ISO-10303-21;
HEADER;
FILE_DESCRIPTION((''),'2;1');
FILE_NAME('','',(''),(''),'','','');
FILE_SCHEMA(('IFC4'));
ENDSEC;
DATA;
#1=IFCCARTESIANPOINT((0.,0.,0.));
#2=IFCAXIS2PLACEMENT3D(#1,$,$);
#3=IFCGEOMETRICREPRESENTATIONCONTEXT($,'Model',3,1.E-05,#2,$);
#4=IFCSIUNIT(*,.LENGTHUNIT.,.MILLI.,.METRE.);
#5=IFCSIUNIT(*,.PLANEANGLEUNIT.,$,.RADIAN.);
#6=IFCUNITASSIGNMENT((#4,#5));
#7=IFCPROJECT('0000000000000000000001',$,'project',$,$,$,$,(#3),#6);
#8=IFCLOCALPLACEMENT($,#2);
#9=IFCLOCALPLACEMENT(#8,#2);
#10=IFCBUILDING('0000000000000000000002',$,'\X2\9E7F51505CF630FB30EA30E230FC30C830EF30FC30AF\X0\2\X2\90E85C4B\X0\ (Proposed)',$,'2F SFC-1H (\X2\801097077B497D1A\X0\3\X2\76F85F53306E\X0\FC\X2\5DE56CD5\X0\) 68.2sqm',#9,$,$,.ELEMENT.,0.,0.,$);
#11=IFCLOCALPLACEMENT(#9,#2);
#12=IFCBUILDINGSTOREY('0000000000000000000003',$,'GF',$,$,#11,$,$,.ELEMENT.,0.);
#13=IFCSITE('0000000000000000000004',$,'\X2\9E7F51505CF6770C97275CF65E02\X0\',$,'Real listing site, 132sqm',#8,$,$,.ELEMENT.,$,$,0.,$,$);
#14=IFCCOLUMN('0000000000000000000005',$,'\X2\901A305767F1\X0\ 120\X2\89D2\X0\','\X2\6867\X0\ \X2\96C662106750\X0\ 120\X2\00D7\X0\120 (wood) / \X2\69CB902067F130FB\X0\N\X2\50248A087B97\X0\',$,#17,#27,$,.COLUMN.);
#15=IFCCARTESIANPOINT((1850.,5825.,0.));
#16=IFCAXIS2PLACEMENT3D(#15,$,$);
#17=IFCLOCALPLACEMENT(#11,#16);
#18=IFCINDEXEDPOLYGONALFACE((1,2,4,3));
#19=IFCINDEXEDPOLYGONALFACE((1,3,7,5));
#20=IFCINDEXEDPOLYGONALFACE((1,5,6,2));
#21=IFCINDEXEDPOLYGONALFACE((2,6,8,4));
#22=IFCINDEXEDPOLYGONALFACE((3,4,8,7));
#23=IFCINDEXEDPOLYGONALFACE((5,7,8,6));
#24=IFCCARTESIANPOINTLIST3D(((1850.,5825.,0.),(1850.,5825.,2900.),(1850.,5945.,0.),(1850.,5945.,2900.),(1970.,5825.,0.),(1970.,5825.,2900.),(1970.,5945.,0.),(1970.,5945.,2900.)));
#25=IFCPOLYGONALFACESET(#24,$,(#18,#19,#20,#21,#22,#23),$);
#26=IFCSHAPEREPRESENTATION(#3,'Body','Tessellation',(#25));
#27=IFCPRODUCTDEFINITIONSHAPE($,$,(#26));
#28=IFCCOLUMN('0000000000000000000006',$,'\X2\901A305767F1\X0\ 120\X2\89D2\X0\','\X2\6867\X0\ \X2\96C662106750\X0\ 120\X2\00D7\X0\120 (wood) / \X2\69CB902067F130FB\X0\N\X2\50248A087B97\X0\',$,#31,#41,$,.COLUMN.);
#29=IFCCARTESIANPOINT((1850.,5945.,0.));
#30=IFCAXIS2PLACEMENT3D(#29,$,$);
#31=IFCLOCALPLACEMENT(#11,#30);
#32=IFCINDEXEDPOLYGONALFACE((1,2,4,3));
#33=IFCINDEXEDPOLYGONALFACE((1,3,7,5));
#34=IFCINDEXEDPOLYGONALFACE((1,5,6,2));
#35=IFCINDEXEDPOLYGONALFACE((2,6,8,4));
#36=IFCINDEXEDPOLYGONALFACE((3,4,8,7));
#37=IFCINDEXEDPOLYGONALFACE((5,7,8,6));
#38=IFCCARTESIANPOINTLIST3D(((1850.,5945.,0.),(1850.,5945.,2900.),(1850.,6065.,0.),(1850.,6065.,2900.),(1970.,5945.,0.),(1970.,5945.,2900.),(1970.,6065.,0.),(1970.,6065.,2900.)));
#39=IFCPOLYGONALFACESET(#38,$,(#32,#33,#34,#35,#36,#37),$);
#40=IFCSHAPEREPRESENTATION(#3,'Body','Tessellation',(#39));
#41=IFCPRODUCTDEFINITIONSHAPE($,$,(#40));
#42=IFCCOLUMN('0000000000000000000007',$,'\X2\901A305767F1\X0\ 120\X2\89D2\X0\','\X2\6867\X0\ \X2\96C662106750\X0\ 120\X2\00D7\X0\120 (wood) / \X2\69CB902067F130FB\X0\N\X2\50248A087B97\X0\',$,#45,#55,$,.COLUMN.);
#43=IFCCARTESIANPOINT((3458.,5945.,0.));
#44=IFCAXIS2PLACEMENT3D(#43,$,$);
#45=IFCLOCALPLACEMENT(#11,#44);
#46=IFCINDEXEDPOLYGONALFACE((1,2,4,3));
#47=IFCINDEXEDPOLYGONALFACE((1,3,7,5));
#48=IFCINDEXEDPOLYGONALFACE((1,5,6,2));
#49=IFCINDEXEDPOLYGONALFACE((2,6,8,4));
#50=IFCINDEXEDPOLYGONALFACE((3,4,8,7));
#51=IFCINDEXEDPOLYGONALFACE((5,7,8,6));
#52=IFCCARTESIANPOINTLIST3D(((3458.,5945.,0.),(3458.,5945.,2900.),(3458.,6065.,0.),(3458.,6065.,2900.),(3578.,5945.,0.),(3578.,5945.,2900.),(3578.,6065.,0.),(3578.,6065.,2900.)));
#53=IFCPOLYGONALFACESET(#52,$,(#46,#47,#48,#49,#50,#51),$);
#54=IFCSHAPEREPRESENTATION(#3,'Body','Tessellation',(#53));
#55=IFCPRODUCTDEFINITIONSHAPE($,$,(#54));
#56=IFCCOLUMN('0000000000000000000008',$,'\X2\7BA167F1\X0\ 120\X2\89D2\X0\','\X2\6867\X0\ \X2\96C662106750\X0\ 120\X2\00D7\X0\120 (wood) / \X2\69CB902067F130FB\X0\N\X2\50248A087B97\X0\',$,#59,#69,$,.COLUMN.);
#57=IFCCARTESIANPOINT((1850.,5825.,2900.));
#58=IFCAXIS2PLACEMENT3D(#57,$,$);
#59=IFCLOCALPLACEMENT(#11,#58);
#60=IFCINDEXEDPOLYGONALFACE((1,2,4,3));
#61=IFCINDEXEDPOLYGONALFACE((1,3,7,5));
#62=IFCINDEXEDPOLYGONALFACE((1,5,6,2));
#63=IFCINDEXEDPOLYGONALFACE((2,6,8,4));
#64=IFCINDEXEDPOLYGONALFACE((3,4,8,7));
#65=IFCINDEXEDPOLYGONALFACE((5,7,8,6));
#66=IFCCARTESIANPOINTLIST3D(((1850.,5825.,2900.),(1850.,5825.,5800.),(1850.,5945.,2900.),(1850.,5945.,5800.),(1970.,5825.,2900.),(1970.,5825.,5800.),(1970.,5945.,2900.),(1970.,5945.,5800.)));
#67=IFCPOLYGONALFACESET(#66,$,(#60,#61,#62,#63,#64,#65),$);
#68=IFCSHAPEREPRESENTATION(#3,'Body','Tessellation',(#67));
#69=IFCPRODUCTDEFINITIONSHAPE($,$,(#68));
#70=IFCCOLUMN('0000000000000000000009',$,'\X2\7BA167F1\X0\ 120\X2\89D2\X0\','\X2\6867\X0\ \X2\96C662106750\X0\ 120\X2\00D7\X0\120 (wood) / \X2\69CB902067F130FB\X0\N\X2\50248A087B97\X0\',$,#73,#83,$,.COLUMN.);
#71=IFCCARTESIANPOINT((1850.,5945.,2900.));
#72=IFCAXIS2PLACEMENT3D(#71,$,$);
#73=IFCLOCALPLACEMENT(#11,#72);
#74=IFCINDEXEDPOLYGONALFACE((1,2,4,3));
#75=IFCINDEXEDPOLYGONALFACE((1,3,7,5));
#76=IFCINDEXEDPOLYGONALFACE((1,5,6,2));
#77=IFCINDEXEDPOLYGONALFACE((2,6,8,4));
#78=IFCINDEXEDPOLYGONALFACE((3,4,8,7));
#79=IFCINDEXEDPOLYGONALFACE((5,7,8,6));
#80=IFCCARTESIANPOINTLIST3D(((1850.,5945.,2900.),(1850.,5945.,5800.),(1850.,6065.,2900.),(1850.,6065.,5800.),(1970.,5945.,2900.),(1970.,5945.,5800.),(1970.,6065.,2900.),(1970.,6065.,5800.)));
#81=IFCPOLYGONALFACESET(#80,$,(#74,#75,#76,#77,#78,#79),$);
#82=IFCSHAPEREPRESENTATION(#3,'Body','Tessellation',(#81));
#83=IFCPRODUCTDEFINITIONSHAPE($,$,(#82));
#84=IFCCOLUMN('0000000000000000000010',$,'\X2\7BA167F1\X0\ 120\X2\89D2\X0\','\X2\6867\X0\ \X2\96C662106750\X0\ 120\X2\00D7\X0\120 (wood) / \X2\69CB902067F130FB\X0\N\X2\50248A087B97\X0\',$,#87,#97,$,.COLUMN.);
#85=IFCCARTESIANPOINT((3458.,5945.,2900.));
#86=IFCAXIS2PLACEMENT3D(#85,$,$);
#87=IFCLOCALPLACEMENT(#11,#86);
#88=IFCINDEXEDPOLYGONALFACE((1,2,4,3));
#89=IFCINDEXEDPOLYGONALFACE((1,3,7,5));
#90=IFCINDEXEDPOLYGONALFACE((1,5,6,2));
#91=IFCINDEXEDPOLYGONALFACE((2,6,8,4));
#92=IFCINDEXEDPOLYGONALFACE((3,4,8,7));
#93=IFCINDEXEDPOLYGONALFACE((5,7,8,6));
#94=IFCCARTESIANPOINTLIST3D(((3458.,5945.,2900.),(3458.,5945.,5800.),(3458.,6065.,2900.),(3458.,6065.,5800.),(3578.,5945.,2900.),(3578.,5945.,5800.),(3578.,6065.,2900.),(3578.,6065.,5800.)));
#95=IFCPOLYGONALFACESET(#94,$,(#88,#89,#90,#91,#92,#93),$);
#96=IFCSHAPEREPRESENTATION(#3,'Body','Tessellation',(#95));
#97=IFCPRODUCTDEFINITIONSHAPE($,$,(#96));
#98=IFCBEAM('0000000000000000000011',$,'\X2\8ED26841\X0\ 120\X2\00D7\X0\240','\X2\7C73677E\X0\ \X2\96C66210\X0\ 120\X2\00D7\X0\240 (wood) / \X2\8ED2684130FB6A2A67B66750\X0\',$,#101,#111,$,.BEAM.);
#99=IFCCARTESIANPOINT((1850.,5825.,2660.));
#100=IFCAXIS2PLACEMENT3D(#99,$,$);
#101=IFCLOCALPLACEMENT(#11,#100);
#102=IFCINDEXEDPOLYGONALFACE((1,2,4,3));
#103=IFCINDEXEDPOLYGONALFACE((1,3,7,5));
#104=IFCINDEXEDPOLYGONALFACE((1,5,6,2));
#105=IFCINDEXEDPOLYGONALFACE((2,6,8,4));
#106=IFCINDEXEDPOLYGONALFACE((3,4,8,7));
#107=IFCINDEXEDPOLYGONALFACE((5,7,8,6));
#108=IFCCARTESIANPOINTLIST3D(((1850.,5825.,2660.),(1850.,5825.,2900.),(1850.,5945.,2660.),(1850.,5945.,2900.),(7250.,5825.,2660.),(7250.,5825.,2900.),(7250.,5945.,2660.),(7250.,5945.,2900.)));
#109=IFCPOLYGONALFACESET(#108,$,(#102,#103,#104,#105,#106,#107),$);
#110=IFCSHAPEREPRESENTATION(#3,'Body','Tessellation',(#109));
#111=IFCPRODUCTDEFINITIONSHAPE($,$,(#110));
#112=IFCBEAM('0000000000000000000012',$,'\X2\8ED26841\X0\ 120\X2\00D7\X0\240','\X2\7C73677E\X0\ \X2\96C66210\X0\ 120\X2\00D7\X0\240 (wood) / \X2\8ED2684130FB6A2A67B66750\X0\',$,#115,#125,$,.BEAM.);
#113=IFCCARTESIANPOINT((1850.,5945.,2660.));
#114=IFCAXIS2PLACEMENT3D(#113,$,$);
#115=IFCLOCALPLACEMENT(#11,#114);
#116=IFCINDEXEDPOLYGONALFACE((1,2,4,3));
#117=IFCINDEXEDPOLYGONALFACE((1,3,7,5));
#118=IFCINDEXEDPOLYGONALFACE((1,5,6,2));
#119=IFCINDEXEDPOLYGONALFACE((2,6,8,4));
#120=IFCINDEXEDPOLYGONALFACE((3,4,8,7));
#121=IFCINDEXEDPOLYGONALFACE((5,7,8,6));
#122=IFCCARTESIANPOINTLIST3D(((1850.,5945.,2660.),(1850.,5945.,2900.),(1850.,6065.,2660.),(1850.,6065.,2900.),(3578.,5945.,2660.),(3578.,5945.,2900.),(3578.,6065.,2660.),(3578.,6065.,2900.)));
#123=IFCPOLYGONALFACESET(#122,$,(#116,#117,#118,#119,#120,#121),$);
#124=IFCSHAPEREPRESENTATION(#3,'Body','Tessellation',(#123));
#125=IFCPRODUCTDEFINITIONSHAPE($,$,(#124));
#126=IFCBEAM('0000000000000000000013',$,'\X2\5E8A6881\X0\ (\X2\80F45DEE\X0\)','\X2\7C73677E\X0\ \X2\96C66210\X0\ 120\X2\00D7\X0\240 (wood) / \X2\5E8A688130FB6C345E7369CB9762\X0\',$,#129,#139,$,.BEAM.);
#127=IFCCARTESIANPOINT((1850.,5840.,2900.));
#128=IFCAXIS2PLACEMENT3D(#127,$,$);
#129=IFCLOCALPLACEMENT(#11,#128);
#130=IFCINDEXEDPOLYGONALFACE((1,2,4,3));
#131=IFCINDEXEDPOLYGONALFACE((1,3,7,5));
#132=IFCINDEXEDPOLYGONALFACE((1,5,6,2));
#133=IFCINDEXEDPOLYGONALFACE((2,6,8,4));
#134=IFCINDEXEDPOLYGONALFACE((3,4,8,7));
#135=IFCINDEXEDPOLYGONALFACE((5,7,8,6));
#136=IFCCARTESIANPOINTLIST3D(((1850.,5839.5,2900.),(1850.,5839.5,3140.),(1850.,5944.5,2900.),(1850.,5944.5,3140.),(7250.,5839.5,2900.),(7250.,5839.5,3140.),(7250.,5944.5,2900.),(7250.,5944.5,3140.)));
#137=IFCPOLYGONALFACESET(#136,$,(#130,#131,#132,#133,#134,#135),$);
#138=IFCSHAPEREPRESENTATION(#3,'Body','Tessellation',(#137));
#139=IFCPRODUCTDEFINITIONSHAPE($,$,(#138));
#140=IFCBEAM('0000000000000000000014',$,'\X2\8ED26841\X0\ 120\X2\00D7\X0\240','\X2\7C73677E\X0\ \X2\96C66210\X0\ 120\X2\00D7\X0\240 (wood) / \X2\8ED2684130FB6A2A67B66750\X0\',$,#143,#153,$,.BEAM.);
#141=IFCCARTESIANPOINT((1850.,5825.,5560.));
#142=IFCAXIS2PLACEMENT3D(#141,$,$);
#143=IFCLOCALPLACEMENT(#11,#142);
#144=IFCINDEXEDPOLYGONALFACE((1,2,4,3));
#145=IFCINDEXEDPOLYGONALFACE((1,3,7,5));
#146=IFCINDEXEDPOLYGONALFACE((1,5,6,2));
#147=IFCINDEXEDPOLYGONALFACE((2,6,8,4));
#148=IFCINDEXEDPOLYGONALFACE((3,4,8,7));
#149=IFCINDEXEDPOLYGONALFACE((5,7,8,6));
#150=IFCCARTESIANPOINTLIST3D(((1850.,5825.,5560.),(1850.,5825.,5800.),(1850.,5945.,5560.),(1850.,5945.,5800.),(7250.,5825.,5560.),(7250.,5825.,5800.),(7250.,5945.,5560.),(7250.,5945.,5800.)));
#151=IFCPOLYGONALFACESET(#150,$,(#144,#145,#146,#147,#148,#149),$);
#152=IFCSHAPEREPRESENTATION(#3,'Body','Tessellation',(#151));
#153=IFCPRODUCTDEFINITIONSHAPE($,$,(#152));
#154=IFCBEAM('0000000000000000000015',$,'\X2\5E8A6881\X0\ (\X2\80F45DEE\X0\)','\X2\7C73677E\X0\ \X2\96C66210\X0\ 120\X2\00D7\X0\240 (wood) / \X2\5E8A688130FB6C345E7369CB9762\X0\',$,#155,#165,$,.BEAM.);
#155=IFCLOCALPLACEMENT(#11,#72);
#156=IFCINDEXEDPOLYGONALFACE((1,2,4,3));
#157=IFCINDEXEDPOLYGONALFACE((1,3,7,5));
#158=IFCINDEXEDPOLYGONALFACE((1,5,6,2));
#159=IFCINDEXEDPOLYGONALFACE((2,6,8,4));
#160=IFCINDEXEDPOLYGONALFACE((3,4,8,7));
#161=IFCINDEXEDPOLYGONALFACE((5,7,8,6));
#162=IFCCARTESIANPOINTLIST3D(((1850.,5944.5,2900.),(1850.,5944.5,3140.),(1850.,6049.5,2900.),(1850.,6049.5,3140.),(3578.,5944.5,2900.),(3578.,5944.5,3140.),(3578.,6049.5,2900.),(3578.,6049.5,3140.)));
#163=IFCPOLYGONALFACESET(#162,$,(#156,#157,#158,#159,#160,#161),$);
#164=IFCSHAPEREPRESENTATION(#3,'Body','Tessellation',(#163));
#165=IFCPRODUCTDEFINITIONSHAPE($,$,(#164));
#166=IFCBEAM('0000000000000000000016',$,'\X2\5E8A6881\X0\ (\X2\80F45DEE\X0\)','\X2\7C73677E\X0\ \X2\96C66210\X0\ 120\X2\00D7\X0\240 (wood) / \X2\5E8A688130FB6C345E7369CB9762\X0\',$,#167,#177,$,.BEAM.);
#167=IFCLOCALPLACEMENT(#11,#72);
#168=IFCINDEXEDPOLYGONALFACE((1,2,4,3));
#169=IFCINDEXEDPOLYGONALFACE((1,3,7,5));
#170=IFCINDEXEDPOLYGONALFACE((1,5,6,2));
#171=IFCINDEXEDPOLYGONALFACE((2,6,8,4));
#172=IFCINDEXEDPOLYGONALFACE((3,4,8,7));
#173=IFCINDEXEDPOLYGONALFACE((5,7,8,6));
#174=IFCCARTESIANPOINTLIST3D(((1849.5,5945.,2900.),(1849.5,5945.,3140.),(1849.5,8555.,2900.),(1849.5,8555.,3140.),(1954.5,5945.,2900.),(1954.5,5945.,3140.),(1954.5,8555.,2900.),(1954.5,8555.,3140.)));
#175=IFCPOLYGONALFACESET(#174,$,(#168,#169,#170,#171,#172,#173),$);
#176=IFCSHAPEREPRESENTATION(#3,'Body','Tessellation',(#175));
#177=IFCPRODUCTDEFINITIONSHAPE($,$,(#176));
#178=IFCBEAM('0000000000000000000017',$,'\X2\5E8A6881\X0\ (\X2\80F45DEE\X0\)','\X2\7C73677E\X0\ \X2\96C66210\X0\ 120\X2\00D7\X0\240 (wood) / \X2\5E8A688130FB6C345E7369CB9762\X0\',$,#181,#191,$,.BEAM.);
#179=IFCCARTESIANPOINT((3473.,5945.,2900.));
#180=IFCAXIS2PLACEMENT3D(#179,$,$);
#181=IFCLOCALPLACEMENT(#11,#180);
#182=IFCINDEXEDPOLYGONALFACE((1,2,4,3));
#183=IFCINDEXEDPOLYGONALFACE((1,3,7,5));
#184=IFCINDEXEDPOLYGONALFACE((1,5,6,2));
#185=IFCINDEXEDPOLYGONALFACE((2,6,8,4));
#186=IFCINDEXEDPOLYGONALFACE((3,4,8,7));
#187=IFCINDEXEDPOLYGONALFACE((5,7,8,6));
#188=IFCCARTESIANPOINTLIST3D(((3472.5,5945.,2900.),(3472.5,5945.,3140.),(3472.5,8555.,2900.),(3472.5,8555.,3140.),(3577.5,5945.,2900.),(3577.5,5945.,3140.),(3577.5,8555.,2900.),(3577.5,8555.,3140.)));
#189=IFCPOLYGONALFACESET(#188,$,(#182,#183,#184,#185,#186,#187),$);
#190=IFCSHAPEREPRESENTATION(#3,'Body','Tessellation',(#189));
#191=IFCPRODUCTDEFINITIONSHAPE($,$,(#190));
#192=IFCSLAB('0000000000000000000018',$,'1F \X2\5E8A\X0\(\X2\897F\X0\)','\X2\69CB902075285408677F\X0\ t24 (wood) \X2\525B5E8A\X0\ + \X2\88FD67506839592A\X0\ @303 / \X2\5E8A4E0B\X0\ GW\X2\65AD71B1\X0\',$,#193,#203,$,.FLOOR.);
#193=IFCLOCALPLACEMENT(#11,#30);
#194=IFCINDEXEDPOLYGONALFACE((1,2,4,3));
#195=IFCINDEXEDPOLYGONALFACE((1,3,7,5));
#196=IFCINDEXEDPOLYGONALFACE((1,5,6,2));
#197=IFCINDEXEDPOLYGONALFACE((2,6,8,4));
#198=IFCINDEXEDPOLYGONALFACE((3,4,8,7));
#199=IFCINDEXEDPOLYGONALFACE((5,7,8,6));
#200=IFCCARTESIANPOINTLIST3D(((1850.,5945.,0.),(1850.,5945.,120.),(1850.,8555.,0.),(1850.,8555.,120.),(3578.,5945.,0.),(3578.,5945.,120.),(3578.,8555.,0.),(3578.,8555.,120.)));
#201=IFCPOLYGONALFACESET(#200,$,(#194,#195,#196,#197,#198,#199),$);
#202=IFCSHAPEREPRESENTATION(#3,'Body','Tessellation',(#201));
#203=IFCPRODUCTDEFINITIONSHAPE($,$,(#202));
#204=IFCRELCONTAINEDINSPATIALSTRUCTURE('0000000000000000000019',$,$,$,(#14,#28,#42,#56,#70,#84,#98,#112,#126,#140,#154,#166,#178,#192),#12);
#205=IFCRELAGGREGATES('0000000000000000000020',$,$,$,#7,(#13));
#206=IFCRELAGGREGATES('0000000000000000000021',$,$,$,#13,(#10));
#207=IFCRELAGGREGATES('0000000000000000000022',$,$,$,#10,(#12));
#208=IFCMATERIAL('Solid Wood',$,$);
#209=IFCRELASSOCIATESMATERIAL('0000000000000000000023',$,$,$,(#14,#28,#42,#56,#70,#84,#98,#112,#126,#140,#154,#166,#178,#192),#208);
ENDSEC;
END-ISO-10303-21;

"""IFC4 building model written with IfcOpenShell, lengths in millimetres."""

from ifc_helpers import new_model, si_unit, frame, frame_2d, origin, place, context, project, spatial, rectangle, extrude, material, element, save


model = new_model("IFC4")

# Units and contexts
model_context = context("Model", 3, precision=1e-05, world=origin())
ifc_project = project(units=[si_unit("LENGTHUNIT", "METRE", prefix="MILLI"), si_unit("PLANEANGLEUNIT", "RADIAN")], contexts=[model_context])

# Site, building, storey
site_placement = place(None, origin())
site = spatial("IfcSite", under=ifc_project, at=site_placement, Name="鹿児島県霧島市", ObjectType="Real listing site, 132sqm", CompositionType="ELEMENT", RefElevation=0.0)
building_placement = place(site_placement, origin())
building = spatial("IfcBuilding", under=site, at=building_placement, Name="鹿児島・リモートワーク2部屋 (Proposed)", ObjectType="2F SFC-1H (耐震等級3相当のFC工法) 68.2sqm", CompositionType="ELEMENT", ElevationOfRefHeight=0.0, ElevationOfTerrain=0.0)
storey_placement = place(building_placement, origin())
storey = spatial("IfcBuildingStorey", under=building, at=storey_placement, Name="GF", CompositionType="ELEMENT", Elevation=0.0)

# Columns
ifc_material_1 = material(Name="Solid Wood")
column_1_placement = place(storey_placement, frame((1850.0, 5825.0, 0.0)))
element("IfcColumn", 1, at=column_1_placement, inside=storey, material=ifc_material_1, Name="通し柱 120角", Description="桧 集成材 120×120 (wood) / 構造柱・N値計算", PredefinedType="COLUMN", context=model_context, shape_type="SweptSolid", body=[
    extrude(rectangle(XDim=120.0, YDim=120.0, at=frame_2d((60.0, 60.0))), frame((1850.0, 5825.0, 0.0)), (0.0, 0.0, 1.0), 2900.0),
])
column_2_placement = place(storey_placement, frame((1850.0, 5945.0, 0.0)))
element("IfcColumn", 2, at=column_2_placement, inside=storey, material=ifc_material_1, Name="通し柱 120角", Description="桧 集成材 120×120 (wood) / 構造柱・N値計算", PredefinedType="COLUMN", context=model_context, shape_type="SweptSolid", body=[
    extrude(rectangle(XDim=120.0, YDim=120.0, at=frame_2d((60.0, 60.0))), frame((1850.0, 5945.0, 0.0)), (0.0, 0.0, 1.0), 2900.0),
])
column_3_placement = place(storey_placement, frame((3458.0, 5945.0, 0.0)))
element("IfcColumn", 3, at=column_3_placement, inside=storey, material=ifc_material_1, Name="通し柱 120角", Description="桧 集成材 120×120 (wood) / 構造柱・N値計算", PredefinedType="COLUMN", context=model_context, shape_type="SweptSolid", body=[
    extrude(rectangle(XDim=120.0, YDim=120.0, at=frame_2d((60.0, 60.0))), frame((3458.0, 5945.0, 0.0)), (0.0, 0.0, 1.0), 2900.0),
])
column_4_placement = place(storey_placement, frame((1850.0, 5825.0, 2900.0)))
element("IfcColumn", 4, at=column_4_placement, inside=storey, material=ifc_material_1, Name="管柱 120角", Description="桧 集成材 120×120 (wood) / 構造柱・N値計算", PredefinedType="COLUMN", context=model_context, shape_type="SweptSolid", body=[
    extrude(rectangle(XDim=120.0, YDim=120.0, at=frame_2d((60.0, 60.0))), frame((1850.0, 5825.0, 2900.0)), (0.0, 0.0, 1.0), 2900.0),
])
column_5_placement = place(storey_placement, frame((1850.0, 5945.0, 2900.0)))
element("IfcColumn", 5, at=column_5_placement, inside=storey, material=ifc_material_1, Name="管柱 120角", Description="桧 集成材 120×120 (wood) / 構造柱・N値計算", PredefinedType="COLUMN", context=model_context, shape_type="SweptSolid", body=[
    extrude(rectangle(XDim=120.0, YDim=120.0, at=frame_2d((60.0, 60.0))), frame((1850.0, 5945.0, 2900.0)), (0.0, 0.0, 1.0), 2900.0),
])
column_6_placement = place(storey_placement, frame((3458.0, 5945.0, 2900.0)))
element("IfcColumn", 6, at=column_6_placement, inside=storey, material=ifc_material_1, Name="管柱 120角", Description="桧 集成材 120×120 (wood) / 構造柱・N値計算", PredefinedType="COLUMN", context=model_context, shape_type="SweptSolid", body=[
    extrude(rectangle(XDim=120.0, YDim=120.0, at=frame_2d((60.0, 60.0))), frame((3458.0, 5945.0, 2900.0)), (0.0, 0.0, 1.0), 2900.0),
])

# Beams
beam_1_placement = place(storey_placement, frame((1850.0, 5825.0, 2660.0)))
element("IfcBeam", 7, at=beam_1_placement, inside=storey, material=ifc_material_1, Name="軒桁 120×240", Description="米松 集成 120×240 (wood) / 軒桁・横架材", PredefinedType="BEAM", context=model_context, shape_type="SweptSolid", body=[
    extrude(rectangle(XDim=5400.0, YDim=120.0, at=frame_2d((2700.0, 60.0))), frame((1850.0, 5825.0, 2660.0)), (0.0, 0.0, 1.0), 240.0),
])
beam_2_placement = place(storey_placement, frame((1850.0, 5945.0, 2660.0)))
element("IfcBeam", 8, at=beam_2_placement, inside=storey, material=ifc_material_1, Name="軒桁 120×240", Description="米松 集成 120×240 (wood) / 軒桁・横架材", PredefinedType="BEAM", context=model_context, shape_type="SweptSolid", body=[
    extrude(rectangle(XDim=1728.0, YDim=120.0, at=frame_2d((864.0, 60.0))), frame((1850.0, 5945.0, 2660.0)), (0.0, 0.0, 1.0), 240.0),
])
beam_3_placement = place(storey_placement, frame((1850.0, 5840.0, 2900.0)))
element("IfcBeam", 9, at=beam_3_placement, inside=storey, material=ifc_material_1, Name="床梁 (胴差)", Description="米松 集成 120×240 (wood) / 床梁・水平構面", PredefinedType="BEAM", context=model_context, shape_type="SweptSolid", body=[
    extrude(rectangle(XDim=5400.0, YDim=105.0, at=frame_2d((2700.0, 52.0))), frame((1850.0, 5840.0, 2900.0)), (0.0, 0.0, 1.0), 240.0),
])
beam_4_placement = place(storey_placement, frame((1850.0, 5825.0, 5560.0)))
element("IfcBeam", 10, at=beam_4_placement, inside=storey, material=ifc_material_1, Name="軒桁 120×240", Description="米松 集成 120×240 (wood) / 軒桁・横架材", PredefinedType="BEAM", context=model_context, shape_type="SweptSolid", body=[
    extrude(rectangle(XDim=5400.0, YDim=120.0, at=frame_2d((2700.0, 60.0))), frame((1850.0, 5825.0, 5560.0)), (0.0, 0.0, 1.0), 240.0),
])
beam_5_placement = place(storey_placement, frame((1850.0, 5945.0, 2900.0)))
element("IfcBeam", 11, at=beam_5_placement, inside=storey, material=ifc_material_1, Name="床梁 (胴差)", Description="米松 集成 120×240 (wood) / 床梁・水平構面", PredefinedType="BEAM", context=model_context, shape_type="SweptSolid", body=[
    extrude(rectangle(XDim=1728.0, YDim=105.0, at=frame_2d((864.0, 52.0))), frame((1850.0, 5945.0, 2900.0)), (0.0, 0.0, 1.0), 240.0),
])
beam_6_placement = place(storey_placement, frame((1850.0, 5945.0, 2900.0)))
element("IfcBeam", 12, at=beam_6_placement, inside=storey, material=ifc_material_1, Name="床梁 (胴差)", Description="米松 集成 120×240 (wood) / 床梁・水平構面", PredefinedType="BEAM", context=model_context, shape_type="SweptSolid", body=[
    extrude(rectangle(XDim=105.0, YDim=2610.0, at=frame_2d((52.0, 1305.0))), frame((1850.0, 5945.0, 2900.0)), (0.0, 0.0, 1.0), 240.0),
])
beam_7_placement = place(storey_placement, frame((3473.0, 5945.0, 2900.0)))
element("IfcBeam", 13, at=beam_7_placement, inside=storey, material=ifc_material_1, Name="床梁 (胴差)", Description="米松 集成 120×240 (wood) / 床梁・水平構面", PredefinedType="BEAM", context=model_context, shape_type="SweptSolid", body=[
    extrude(rectangle(XDim=105.0, YDim=2610.0, at=frame_2d((52.0, 1305.0))), frame((3473.0, 5945.0, 2900.0)), (0.0, 0.0, 1.0), 240.0),
])

# Slab
slab_1_placement = place(storey_placement, frame((1850.0, 5945.0, 0.0)))
element("IfcSlab", 14, at=slab_1_placement, inside=storey, material=ifc_material_1, Name="1F 床(西)", Description="構造用合板 t24 (wood) 剛床 + 製材根太 @303 / 床下 GW断熱", PredefinedType="FLOOR", context=model_context, shape_type="SweptSolid", body=[
    extrude(rectangle(XDim=1728.0, YDim=2610.0, at=frame_2d((864.0, 1305.0))), frame((1850.0, 5945.0, 0.0)), (0.0, 0.0, 1.0), 120.0),
])

save(model, "model.ifc")
